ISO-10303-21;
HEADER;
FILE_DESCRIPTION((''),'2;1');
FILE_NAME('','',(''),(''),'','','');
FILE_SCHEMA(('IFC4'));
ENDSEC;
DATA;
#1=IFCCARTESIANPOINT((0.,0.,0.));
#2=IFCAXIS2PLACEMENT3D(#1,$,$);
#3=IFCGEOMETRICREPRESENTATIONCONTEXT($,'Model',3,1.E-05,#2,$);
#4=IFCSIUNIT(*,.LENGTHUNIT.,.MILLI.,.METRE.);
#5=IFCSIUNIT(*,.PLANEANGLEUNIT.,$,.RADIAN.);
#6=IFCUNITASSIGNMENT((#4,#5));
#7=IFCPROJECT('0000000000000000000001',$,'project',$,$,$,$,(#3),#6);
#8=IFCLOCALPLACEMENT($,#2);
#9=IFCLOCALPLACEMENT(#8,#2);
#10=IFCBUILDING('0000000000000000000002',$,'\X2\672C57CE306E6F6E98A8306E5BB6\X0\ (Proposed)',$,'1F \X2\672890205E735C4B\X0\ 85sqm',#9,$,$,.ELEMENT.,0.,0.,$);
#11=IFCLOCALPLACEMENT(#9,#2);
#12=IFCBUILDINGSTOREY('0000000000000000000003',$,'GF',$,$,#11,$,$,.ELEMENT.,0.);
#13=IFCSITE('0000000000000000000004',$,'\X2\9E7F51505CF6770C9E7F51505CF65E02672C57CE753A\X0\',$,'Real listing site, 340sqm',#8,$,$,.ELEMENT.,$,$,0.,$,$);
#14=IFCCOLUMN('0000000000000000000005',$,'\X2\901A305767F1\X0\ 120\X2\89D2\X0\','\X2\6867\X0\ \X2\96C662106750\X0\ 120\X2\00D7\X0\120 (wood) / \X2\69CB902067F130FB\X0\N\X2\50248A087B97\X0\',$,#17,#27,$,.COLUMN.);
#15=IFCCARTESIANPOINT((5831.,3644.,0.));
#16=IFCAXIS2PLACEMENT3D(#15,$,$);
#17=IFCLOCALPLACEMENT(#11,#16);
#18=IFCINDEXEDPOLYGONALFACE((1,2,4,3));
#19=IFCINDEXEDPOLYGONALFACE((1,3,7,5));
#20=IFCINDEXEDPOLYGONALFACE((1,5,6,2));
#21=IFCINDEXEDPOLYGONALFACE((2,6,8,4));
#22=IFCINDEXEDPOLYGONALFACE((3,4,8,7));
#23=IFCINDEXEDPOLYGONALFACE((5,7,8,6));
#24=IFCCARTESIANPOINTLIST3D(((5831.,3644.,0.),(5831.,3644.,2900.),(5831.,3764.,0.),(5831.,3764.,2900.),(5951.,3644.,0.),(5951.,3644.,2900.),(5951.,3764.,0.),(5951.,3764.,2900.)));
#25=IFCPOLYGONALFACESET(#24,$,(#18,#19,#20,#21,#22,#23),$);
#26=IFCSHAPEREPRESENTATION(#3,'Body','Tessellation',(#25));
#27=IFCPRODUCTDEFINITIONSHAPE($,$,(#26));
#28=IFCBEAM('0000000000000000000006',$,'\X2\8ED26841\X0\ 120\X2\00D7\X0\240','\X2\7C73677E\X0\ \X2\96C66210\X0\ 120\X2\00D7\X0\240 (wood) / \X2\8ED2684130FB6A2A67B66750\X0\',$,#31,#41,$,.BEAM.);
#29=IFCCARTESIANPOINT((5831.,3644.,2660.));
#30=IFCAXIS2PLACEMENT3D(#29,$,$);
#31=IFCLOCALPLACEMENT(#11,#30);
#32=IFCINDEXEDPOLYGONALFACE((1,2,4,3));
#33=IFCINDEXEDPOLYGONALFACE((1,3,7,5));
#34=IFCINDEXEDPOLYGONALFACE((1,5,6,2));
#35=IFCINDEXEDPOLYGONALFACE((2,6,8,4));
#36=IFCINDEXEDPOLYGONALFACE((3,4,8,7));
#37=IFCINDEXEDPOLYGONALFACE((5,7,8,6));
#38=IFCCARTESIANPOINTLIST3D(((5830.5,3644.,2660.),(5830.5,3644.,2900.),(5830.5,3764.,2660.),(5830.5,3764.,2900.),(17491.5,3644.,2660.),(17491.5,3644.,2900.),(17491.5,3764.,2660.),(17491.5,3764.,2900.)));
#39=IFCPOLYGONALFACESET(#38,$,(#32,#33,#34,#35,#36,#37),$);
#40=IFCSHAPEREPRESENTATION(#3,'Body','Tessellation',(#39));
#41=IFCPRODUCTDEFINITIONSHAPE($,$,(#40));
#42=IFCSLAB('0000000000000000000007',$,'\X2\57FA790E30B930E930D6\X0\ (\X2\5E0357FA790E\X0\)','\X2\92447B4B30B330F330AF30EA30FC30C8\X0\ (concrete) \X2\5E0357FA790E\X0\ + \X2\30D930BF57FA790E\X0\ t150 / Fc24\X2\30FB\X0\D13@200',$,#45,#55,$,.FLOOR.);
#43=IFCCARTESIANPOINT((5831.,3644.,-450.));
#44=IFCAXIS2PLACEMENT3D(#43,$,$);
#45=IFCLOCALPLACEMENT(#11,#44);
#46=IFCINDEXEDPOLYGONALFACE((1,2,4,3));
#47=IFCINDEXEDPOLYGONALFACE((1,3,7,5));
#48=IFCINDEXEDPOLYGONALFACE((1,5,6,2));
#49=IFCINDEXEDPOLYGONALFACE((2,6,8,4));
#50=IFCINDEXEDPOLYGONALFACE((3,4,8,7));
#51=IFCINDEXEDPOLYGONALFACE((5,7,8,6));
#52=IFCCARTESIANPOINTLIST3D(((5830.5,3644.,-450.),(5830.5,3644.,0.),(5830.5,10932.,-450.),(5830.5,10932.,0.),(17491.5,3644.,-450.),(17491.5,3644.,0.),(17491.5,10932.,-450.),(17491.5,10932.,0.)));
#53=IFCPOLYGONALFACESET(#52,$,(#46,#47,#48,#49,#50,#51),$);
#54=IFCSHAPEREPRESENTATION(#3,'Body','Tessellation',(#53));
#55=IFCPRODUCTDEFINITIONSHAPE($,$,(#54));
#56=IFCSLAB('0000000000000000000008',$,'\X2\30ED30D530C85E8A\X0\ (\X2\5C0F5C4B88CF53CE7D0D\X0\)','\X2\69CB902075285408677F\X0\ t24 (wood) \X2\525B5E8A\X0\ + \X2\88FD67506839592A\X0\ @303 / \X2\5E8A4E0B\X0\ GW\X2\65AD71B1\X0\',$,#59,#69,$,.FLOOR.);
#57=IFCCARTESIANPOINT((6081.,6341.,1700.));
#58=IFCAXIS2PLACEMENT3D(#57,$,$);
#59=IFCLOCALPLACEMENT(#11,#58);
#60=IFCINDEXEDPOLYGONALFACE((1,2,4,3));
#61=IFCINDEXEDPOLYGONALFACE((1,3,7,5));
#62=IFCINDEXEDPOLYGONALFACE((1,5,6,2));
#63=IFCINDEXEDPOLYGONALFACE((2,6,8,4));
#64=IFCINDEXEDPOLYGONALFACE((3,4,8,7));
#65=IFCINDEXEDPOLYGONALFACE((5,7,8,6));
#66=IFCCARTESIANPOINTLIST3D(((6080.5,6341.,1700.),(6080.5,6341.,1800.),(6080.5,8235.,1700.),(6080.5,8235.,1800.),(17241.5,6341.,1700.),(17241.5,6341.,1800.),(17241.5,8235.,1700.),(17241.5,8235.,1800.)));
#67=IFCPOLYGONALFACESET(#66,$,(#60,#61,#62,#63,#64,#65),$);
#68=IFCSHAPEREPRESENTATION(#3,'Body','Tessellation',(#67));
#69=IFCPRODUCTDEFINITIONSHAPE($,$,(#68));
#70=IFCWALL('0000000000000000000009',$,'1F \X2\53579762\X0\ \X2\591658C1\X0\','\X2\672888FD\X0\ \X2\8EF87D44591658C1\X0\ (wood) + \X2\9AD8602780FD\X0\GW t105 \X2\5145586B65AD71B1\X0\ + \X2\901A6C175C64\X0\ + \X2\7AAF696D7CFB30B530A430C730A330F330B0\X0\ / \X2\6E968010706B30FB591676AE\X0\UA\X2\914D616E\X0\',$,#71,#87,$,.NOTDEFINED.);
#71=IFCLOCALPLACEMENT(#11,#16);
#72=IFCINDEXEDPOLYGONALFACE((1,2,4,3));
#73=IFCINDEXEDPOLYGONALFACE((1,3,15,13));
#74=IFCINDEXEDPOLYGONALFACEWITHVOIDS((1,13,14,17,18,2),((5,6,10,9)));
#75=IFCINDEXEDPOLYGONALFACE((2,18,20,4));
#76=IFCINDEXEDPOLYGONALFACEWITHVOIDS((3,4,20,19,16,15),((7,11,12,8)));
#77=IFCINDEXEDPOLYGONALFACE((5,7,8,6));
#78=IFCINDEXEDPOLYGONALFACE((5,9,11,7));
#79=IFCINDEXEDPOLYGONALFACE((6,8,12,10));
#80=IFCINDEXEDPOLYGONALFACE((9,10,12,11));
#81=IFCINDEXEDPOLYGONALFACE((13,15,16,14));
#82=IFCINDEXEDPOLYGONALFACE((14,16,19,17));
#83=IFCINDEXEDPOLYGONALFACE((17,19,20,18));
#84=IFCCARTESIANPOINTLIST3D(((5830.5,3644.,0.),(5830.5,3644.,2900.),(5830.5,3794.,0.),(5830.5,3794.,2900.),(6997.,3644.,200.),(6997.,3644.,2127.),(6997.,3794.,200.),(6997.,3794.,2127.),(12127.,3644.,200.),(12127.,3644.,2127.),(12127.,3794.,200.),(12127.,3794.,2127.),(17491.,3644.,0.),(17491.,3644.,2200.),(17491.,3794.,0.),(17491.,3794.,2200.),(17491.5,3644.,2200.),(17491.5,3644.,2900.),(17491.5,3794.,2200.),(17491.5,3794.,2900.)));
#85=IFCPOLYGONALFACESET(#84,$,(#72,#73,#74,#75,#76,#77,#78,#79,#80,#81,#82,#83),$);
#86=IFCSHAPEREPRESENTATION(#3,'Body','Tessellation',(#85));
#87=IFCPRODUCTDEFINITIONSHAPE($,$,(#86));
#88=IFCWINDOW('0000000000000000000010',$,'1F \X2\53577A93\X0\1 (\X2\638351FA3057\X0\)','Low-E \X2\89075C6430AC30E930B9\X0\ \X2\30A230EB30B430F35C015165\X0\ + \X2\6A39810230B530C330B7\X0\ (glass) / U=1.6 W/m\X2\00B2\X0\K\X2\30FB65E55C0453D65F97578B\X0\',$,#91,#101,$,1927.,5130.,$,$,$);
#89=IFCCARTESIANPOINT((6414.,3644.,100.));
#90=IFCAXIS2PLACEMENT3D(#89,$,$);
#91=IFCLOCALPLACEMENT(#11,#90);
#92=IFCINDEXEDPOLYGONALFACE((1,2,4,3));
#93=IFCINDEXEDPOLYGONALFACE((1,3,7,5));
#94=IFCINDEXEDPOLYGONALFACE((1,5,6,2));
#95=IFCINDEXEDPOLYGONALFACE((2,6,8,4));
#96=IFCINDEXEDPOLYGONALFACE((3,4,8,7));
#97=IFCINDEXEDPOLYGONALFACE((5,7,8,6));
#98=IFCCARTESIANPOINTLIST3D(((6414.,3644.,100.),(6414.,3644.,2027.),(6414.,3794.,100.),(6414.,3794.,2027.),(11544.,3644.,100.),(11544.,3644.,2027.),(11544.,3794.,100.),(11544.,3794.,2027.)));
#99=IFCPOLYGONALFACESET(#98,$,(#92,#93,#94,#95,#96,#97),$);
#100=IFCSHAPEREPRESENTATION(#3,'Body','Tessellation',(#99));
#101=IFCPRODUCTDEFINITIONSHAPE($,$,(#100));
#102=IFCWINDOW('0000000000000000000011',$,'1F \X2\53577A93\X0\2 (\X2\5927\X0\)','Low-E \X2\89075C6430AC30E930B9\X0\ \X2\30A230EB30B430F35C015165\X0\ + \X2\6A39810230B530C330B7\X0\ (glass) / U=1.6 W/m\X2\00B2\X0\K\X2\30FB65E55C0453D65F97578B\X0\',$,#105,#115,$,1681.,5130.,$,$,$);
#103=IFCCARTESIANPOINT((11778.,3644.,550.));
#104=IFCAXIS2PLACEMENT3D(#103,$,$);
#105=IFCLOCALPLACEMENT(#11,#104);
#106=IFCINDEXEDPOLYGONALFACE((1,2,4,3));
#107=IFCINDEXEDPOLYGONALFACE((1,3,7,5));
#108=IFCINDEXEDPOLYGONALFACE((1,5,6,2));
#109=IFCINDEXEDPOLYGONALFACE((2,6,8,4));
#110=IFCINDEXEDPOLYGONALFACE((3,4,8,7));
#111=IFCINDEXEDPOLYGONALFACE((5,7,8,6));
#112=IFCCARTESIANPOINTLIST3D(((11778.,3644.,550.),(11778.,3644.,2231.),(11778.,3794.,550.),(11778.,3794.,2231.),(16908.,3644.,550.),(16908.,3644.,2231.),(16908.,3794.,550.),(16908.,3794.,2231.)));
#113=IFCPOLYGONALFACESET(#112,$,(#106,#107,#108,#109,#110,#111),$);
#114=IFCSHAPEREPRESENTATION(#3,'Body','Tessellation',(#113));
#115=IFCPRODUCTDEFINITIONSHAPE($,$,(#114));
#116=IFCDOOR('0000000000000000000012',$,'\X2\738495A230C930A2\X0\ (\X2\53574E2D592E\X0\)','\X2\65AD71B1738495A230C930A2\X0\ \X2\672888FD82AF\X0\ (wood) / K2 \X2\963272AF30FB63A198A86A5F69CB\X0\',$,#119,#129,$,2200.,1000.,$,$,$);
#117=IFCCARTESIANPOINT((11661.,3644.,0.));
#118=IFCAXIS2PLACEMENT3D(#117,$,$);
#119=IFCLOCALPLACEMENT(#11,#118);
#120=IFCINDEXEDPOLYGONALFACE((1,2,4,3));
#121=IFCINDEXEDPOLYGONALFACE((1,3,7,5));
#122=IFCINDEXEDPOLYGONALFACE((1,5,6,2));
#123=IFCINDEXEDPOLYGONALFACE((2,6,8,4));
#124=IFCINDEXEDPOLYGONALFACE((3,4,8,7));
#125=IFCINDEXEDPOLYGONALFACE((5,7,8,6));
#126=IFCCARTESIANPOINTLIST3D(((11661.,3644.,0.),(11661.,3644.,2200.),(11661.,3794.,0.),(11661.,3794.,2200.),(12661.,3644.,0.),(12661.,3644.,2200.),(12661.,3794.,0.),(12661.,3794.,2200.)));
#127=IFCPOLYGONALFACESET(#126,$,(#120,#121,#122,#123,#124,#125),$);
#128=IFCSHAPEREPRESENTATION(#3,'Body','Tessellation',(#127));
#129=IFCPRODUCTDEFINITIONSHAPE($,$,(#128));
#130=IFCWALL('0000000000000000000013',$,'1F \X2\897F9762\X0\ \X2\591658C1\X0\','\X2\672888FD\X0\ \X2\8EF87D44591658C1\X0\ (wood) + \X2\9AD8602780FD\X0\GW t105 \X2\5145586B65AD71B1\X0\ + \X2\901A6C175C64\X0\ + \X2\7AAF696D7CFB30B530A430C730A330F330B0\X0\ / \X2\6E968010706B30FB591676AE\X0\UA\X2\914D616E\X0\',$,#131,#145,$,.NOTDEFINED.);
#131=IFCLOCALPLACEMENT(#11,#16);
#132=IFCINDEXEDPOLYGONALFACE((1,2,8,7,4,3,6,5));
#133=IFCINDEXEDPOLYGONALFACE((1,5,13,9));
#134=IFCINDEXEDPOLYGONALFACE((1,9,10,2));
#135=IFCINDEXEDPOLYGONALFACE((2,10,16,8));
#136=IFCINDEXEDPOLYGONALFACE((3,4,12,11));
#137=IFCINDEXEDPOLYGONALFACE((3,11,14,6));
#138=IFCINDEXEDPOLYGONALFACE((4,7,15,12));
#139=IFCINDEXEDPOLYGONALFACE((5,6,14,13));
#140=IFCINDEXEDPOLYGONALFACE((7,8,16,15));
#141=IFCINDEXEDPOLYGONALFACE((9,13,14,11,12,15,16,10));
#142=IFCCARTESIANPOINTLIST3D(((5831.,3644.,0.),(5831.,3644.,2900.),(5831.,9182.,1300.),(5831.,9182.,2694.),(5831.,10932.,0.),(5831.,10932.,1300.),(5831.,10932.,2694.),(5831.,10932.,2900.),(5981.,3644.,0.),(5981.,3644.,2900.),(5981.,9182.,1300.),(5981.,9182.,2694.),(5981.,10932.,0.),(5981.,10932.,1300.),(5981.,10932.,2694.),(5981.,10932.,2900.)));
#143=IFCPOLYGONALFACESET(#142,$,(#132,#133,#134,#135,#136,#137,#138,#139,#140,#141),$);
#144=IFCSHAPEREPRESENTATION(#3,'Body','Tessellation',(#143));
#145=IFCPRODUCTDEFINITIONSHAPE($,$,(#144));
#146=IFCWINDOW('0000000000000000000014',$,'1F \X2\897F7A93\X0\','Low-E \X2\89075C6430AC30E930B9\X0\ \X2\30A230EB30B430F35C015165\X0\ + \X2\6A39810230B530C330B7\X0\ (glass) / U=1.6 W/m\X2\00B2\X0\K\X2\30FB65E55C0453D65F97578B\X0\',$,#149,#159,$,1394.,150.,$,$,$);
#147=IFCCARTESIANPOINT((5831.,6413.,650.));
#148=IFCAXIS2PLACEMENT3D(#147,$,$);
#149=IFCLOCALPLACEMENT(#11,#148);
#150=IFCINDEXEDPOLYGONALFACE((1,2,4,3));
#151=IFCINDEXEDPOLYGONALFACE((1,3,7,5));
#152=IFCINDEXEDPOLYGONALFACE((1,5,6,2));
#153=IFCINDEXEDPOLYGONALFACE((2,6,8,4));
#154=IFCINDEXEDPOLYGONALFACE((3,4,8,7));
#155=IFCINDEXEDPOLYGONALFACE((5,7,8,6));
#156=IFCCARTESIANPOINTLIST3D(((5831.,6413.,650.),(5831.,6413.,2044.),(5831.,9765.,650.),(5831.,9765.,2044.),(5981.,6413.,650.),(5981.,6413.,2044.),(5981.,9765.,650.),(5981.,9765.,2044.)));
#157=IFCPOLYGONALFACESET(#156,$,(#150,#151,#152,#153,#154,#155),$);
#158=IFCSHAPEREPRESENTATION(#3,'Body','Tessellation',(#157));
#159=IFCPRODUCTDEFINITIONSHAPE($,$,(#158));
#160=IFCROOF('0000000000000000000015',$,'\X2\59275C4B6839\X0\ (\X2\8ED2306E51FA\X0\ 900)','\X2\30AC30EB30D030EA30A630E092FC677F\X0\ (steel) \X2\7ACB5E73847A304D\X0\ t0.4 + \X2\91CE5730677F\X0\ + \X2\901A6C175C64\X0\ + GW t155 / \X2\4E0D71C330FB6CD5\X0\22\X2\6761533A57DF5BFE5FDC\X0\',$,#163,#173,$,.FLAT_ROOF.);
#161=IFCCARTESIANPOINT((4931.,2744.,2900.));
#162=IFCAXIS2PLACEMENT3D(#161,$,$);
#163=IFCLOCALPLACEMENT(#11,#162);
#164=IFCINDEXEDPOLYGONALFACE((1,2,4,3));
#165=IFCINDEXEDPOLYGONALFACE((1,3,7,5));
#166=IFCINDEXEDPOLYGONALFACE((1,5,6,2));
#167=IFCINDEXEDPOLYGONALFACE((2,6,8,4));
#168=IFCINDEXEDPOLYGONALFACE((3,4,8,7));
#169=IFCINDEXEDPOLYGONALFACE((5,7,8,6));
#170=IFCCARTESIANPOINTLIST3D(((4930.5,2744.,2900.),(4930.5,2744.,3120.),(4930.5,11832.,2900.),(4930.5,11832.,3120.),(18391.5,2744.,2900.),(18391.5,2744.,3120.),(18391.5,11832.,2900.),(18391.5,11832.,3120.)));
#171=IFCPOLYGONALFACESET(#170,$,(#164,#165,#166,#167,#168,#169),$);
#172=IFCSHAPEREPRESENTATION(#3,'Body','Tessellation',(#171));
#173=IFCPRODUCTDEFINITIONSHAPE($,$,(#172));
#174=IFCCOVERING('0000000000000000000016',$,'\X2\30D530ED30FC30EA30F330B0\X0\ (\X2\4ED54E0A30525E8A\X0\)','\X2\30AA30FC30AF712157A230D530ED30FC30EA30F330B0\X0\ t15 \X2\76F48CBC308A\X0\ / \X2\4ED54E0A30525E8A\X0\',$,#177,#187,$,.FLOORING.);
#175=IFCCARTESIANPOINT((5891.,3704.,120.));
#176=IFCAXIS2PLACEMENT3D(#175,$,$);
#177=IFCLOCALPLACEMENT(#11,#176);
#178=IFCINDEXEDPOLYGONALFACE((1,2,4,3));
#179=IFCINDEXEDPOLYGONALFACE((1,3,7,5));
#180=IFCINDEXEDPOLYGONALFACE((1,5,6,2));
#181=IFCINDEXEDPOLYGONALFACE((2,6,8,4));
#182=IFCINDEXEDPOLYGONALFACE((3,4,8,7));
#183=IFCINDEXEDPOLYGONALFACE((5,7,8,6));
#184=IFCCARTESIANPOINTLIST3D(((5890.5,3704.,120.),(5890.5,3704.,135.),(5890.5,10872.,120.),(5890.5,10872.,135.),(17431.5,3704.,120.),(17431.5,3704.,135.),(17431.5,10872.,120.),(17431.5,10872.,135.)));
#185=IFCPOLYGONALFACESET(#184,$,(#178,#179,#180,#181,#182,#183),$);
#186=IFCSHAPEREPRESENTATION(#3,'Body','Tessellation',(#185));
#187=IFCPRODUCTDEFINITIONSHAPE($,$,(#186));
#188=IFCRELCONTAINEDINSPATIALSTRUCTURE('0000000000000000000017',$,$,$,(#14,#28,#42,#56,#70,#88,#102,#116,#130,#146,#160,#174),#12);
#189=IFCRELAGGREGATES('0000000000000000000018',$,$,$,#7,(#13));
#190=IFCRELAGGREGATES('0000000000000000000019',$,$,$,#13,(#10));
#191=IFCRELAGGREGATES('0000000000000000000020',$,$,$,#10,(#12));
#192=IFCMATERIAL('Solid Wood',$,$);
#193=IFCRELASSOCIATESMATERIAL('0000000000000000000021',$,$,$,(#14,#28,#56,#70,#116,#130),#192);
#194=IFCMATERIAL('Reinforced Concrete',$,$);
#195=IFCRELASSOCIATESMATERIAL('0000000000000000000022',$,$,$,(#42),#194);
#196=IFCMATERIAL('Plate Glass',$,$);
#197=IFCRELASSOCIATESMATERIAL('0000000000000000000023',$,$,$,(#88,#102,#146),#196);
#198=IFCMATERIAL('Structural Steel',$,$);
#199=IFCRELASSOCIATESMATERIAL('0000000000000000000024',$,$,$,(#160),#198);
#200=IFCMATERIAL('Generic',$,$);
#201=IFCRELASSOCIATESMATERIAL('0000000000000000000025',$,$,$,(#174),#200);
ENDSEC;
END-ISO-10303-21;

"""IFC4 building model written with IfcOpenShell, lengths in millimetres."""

from ifc_helpers import new_model, si_unit, frame, frame_2d, origin, place, context, project, spatial, rectangle, extrude, material, element, fill, save


model = new_model("IFC4")

# Units and contexts
model_context = context("Model", 3, precision=1e-05, world=origin())
ifc_project = project(units=[si_unit("LENGTHUNIT", "METRE", prefix="MILLI"), si_unit("PLANEANGLEUNIT", "RADIAN")], contexts=[model_context])

# Site, building, storey
site_placement = place(None, origin())
site = spatial("IfcSite", under=ifc_project, at=site_placement, Name="鹿児島県鹿児島市本城町", ObjectType="Real listing site, 340sqm", CompositionType="ELEMENT", RefElevation=0.0)
building_placement = place(site_placement, origin())
building = spatial("IfcBuilding", under=site, at=building_placement, Name="本城の潮風の家 (Proposed)", ObjectType="1F 木造平屋 85sqm", CompositionType="ELEMENT", ElevationOfRefHeight=0.0, ElevationOfTerrain=0.0)
storey_placement = place(building_placement, origin())
storey = spatial("IfcBuildingStorey", under=building, at=storey_placement, Name="GF", CompositionType="ELEMENT", Elevation=0.0)

# Column
ifc_material_1 = material(Name="Solid Wood")
column_1_placement = place(storey_placement, frame((5831.0, 3644.0, 0.0)))
element("IfcColumn", 1, at=column_1_placement, inside=storey, material=ifc_material_1, Name="通し柱 120角", Description="桧 集成材 120×120 (wood) / 構造柱・N値計算", PredefinedType="COLUMN", context=model_context, shape_type="SweptSolid", body=[
    extrude(rectangle(XDim=120.0, YDim=120.0, at=frame_2d((60.0, 60.0))), frame((5831.0, 3644.0, 0.0)), (0.0, 0.0, 1.0), 2900.0),
])

# Beam
beam_1_placement = place(storey_placement, frame((5831.0, 3644.0, 2660.0)))
element("IfcBeam", 2, at=beam_1_placement, inside=storey, material=ifc_material_1, Name="軒桁 120×240", Description="米松 集成 120×240 (wood) / 軒桁・横架材", PredefinedType="BEAM", context=model_context, shape_type="SweptSolid", body=[
    extrude(rectangle(XDim=11661.0, YDim=120.0, at=frame_2d((5830.0, 60.0))), frame((5831.0, 3644.0, 2660.0)), (0.0, 0.0, 1.0), 240.0),
])

# Slabs
ifc_material_2 = material(Name="Reinforced Concrete")
slab_1_placement = place(storey_placement, frame((5831.0, 3644.0, -450.0)))
element("IfcSlab", 3, at=slab_1_placement, inside=storey, material=ifc_material_2, Name="基礎スラブ (布基礎)", Description="鉄筋コンクリート (concrete) 布基礎 + ベタ基礎 t150 / Fc24・D13@200", PredefinedType="FLOOR", context=model_context, shape_type="SweptSolid", body=[
    extrude(rectangle(XDim=11661.0, YDim=7288.0, at=frame_2d((5830.0, 3644.0))), frame((5831.0, 3644.0, -450.0)), (0.0, 0.0, 1.0), 450.0),
])
slab_2_placement = place(storey_placement, frame((6081.0, 6341.0, 1700.0)))
element("IfcSlab", 4, at=slab_2_placement, inside=storey, material=ifc_material_1, Name="ロフト床 (小屋裏収納)", Description="構造用合板 t24 (wood) 剛床 + 製材根太 @303 / 床下 GW断熱", PredefinedType="FLOOR", context=model_context, shape_type="SweptSolid", body=[
    extrude(rectangle(XDim=11161.0, YDim=1894.0, at=frame_2d((5580.0, 947.0))), frame((6081.0, 6341.0, 1700.0)), (0.0, 0.0, 1.0), 100.0),
])

# Wall, openings, windows, door
wall_1_placement = place(storey_placement, frame((5831.0, 3644.0, 0.0)))
wall_1 = element("IfcWall", 5, at=wall_1_placement, inside=storey, material=ifc_material_1, Name="1F 南面 外壁", Description="木製 軸組外壁 (wood) + 高性能GW t105 充填断熱 + 通気層 + 窯業系サイディング / 準耐火・外皮UA配慮", PredefinedType="NOTDEFINED", context=model_context, shape_type="SweptSolid", body=[
    extrude(rectangle(XDim=11661.0, YDim=150.0, at=frame_2d((5830.0, 75.0))), frame((5831.0, 3644.0, 0.0)), (0.0, 0.0, 1.0), 2900.0),
])
opening_1_placement = place(storey_placement, frame((6414.0, 3644.0, 100.0)))
opening_1 = element("IfcOpeningElement", 6, at=opening_1_placement, cuts=wall_1, PredefinedType="NOTDEFINED", context=model_context, shape_type="SweptSolid", body=[
    extrude(rectangle(XDim=5130.0, YDim=150.0, at=frame_2d((2565.0, 75.0))), frame((6414.0, 3644.0, 100.0)), (0.0, 0.0, 1.0), 1927.0),
])
opening_2_placement = place(storey_placement, frame((11778.0, 3644.0, 550.0)))
opening_2 = element("IfcOpeningElement", 7, at=opening_2_placement, cuts=wall_1, PredefinedType="NOTDEFINED", context=model_context, shape_type="SweptSolid", body=[
    extrude(rectangle(XDim=5130.0, YDim=150.0, at=frame_2d((2565.0, 75.0))), frame((11778.0, 3644.0, 550.0)), (0.0, 0.0, 1.0), 1681.0),
])
opening_3_placement = place(storey_placement, frame((11661.0, 3644.0, 0.0)))
opening_3 = element("IfcOpeningElement", 8, at=opening_3_placement, cuts=wall_1, PredefinedType="NOTDEFINED", context=model_context, shape_type="SweptSolid", body=[
    extrude(rectangle(XDim=1000.0, YDim=150.0, at=frame_2d((500.0, 75.0))), frame((11661.0, 3644.0, 0.0)), (0.0, 0.0, 1.0), 2200.0),
])
ifc_material_3 = material(Name="Plate Glass")
window_1_placement = place(storey_placement, frame((6414.0, 3644.0, 100.0)))
window_1 = element("IfcWindow", 9, at=window_1_placement, inside=storey, material=ifc_material_3, Name="1F 南窓1 (掃出し)", Description="Low-E 複層ガラス アルゴン封入 + 樹脂サッシ (glass) / U=1.6 W/m²K・日射取得型", OverallHeight=1927.0, OverallWidth=5130.0, context=model_context, shape_type="SweptSolid", body=[
    extrude(rectangle(XDim=5130.0, YDim=150.0, at=frame_2d((2565.0, 75.0))), frame((6414.0, 3644.0, 100.0)), (0.0, 0.0, 1.0), 1927.0),
])
fill(opening_1, window_1)
window_2_placement = place(storey_placement, frame((11778.0, 3644.0, 550.0)))
window_2 = element("IfcWindow", 10, at=window_2_placement, inside=storey, material=ifc_material_3, Name="1F 南窓2 (大)", Description="Low-E 複層ガラス アルゴン封入 + 樹脂サッシ (glass) / U=1.6 W/m²K・日射取得型", OverallHeight=1681.0, OverallWidth=5130.0, context=model_context, shape_type="SweptSolid", body=[
    extrude(rectangle(XDim=5130.0, YDim=150.0, at=frame_2d((2565.0, 75.0))), frame((11778.0, 3644.0, 550.0)), (0.0, 0.0, 1.0), 1681.0),
])
fill(opening_2, window_2)
door_placement = place(storey_placement, frame((11661.0, 3644.0, 0.0)))
door = element("IfcDoor", 11, at=door_placement, inside=storey, material=ifc_material_1, Name="玄関ドア (南中央)", Description="断熱玄関ドア 木製芯 (wood) / K2 防犯・採風機構", OverallHeight=2200.0, OverallWidth=1000.0, context=model_context, shape_type="SweptSolid", body=[
    extrude(rectangle(XDim=1000.0, YDim=150.0, at=frame_2d((500.0, 75.0))), frame((11661.0, 3644.0, 0.0)), (0.0, 0.0, 1.0), 2200.0),
])
fill(opening_3, door)

# Wall, opening, window
wall_2_placement = place(storey_placement, frame((5831.0, 3644.0, 0.0)))
wall_2 = element("IfcWall", 12, at=wall_2_placement, inside=storey, material=ifc_material_1, Name="1F 西面 外壁", Description="木製 軸組外壁 (wood) + 高性能GW t105 充填断熱 + 通気層 + 窯業系サイディング / 準耐火・外皮UA配慮", PredefinedType="NOTDEFINED", context=model_context, shape_type="SweptSolid", body=[
    extrude(rectangle(XDim=150.0, YDim=7288.0, at=frame_2d((75.0, 3644.0))), frame((5831.0, 3644.0, 0.0)), (0.0, 0.0, 1.0), 2900.0),
])
opening_4_placement = place(storey_placement, frame((5831.0, 6413.0, 650.0)))
opening_4 = element("IfcOpeningElement", 13, at=opening_4_placement, cuts=wall_2, PredefinedType="NOTDEFINED", context=model_context, shape_type="SweptSolid", body=[
    extrude(rectangle(XDim=150.0, YDim=3352.0, at=frame_2d((75.0, 1676.0))), frame((5831.0, 6413.0, 650.0)), (0.0, 0.0, 1.0), 1394.0),
])
window_3_placement = place(storey_placement, frame((5831.0, 6413.0, 650.0)))
window_3 = element("IfcWindow", 14, at=window_3_placement, inside=storey, material=ifc_material_3, Name="1F 西窓", Description="Low-E 複層ガラス アルゴン封入 + 樹脂サッシ (glass) / U=1.6 W/m²K・日射取得型", OverallHeight=1394.0, OverallWidth=150.0, context=model_context, shape_type="SweptSolid", body=[
    extrude(rectangle(XDim=150.0, YDim=3352.0, at=frame_2d((75.0, 1676.0))), frame((5831.0, 6413.0, 650.0)), (0.0, 0.0, 1.0), 1394.0),
])
fill(opening_4, window_3)

# Roof
ifc_material_4 = material(Name="Structural Steel")
roof_placement = place(storey_placement, frame((4931.0, 2744.0, 2900.0)))
element("IfcRoof", 15, at=roof_placement, inside=storey, material=ifc_material_4, Name="大屋根 (軒の出 900)", Description="ガルバリウム鋼板 (steel) 立平葺き t0.4 + 野地板 + 通気層 + GW t155 / 不燃・法22条区域対応", PredefinedType="FLAT_ROOF", context=model_context, shape_type="SweptSolid", body=[
    extrude(rectangle(XDim=13461.0, YDim=9088.0, at=frame_2d((6730.0, 4544.0))), frame((4931.0, 2744.0, 2900.0)), (0.0, 0.0, 1.0), 220.0),
])

# Covering
ifc_material_5 = material(Name="Generic")
covering_1_placement = place(storey_placement, frame((5891.0, 3704.0, 120.0)))
element("IfcCovering", 16, at=covering_1_placement, inside=storey, material=ifc_material_5, Name="フローリング (仕上げ床)", Description="オーク無垢フローリング t15 直貼り / 仕上げ床", PredefinedType="FLOORING", context=model_context, shape_type="SweptSolid", body=[
    extrude(rectangle(XDim=11541.0, YDim=7168.0, at=frame_2d((5770.0, 3584.0))), frame((5891.0, 3704.0, 120.0)), (0.0, 0.0, 1.0), 15.0),
])

save(model, "model.ifc")
